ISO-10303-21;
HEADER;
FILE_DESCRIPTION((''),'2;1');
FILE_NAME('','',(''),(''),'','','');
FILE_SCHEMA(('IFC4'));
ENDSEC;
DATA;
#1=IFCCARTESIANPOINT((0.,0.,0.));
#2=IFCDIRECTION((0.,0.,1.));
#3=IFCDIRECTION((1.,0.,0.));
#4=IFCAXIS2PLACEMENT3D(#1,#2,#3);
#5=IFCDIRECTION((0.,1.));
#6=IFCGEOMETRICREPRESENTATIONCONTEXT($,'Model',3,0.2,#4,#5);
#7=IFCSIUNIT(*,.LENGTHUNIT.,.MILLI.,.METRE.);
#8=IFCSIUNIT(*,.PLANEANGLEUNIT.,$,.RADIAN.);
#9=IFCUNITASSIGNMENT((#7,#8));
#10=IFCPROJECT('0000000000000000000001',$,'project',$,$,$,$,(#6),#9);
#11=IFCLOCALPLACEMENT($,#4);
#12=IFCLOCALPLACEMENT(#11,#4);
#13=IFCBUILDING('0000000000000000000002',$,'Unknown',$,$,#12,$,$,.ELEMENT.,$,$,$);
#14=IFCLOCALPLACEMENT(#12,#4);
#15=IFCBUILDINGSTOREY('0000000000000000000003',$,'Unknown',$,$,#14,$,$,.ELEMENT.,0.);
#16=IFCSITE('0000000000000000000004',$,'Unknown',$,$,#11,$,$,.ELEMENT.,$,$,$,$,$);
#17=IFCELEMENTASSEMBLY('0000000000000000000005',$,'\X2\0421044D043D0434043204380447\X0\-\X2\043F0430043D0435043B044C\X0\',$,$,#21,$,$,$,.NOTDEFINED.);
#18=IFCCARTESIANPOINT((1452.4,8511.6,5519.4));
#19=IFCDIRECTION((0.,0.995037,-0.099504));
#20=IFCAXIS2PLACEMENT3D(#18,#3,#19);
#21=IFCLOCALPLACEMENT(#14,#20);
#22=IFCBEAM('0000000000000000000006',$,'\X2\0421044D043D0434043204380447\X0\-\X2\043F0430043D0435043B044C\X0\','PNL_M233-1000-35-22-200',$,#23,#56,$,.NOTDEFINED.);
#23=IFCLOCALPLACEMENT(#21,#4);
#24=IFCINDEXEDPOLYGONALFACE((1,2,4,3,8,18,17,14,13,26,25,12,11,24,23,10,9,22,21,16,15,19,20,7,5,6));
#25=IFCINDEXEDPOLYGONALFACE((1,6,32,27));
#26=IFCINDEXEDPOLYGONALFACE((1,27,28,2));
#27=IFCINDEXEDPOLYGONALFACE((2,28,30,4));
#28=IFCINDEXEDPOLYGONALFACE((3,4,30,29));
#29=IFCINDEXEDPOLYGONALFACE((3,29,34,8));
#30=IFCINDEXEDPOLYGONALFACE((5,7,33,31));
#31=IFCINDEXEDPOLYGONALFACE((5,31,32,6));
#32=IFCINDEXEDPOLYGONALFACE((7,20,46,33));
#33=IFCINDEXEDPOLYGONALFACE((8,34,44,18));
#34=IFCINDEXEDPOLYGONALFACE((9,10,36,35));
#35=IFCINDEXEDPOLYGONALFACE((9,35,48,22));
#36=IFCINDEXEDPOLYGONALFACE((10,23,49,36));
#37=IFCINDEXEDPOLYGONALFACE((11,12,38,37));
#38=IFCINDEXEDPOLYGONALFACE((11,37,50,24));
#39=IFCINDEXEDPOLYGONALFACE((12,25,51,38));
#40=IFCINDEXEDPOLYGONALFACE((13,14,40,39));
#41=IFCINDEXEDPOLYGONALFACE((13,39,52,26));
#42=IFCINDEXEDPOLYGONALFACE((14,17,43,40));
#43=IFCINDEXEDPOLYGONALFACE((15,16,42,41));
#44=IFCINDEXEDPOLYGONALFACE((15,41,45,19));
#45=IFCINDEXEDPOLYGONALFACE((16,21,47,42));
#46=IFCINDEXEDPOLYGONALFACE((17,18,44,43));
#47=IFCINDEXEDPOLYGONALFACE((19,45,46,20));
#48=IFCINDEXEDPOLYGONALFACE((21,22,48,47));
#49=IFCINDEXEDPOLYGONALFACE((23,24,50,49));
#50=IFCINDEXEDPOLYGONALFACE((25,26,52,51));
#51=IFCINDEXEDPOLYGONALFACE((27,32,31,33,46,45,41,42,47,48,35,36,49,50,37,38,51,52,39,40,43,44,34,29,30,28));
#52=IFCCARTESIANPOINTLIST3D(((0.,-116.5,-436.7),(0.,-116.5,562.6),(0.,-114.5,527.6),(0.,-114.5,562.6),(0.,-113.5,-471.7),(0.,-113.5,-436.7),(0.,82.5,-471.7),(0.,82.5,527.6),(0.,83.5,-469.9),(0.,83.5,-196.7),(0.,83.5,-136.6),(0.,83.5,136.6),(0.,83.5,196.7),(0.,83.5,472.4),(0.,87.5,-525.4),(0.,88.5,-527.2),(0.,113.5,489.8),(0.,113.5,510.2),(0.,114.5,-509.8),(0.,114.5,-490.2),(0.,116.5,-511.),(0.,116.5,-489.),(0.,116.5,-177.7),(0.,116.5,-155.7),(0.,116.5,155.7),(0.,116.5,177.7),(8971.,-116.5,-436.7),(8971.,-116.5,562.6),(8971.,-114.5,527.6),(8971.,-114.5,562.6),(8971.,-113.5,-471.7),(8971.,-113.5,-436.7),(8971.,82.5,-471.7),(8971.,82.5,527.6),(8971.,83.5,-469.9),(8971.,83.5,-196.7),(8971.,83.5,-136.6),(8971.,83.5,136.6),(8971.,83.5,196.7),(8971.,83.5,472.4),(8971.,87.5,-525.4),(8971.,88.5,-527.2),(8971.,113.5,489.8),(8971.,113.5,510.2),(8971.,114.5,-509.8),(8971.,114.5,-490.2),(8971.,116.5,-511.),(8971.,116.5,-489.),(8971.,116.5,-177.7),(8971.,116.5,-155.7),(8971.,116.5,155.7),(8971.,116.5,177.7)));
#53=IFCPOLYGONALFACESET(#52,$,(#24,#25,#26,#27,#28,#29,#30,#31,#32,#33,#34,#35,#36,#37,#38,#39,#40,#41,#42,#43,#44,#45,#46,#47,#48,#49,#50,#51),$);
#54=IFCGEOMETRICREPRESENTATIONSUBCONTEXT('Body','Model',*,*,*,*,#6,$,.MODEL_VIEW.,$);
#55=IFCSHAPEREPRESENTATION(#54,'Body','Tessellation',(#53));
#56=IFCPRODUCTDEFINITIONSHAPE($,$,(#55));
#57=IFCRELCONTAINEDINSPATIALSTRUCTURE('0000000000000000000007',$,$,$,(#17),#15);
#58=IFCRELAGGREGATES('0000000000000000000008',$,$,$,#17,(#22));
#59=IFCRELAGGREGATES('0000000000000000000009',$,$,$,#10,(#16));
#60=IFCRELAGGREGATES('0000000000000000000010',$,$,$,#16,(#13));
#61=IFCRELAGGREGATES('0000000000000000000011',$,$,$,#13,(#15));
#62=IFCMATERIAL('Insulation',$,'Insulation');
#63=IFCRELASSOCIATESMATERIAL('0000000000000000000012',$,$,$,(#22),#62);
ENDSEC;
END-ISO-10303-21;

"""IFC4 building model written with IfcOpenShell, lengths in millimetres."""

from ifc_helpers import new_model, si_unit, direction, frame, origin_with_axes, place, context, subcontext, project, spatial, line, indexed_curve, outline, extrude, material, element, aggregate, save


model = new_model("IFC4")

# Units and contexts
model_context = context("Model", 3, precision=0.2, world=origin_with_axes(), true_north=direction((0.0, 1.0)))
body_context = subcontext(model_context, "Body", "Model", "MODEL_VIEW")
ifc_project = project(units=[si_unit("LENGTHUNIT", "METRE", prefix="MILLI"), si_unit("PLANEANGLEUNIT", "RADIAN")], contexts=[model_context])

# Site, building, storey
site_placement = place(None, origin_with_axes())
site = spatial("IfcSite", under=ifc_project, at=site_placement, Name="Unknown", CompositionType="ELEMENT")
building_placement = place(site_placement, origin_with_axes())
building = spatial("IfcBuilding", under=site, at=building_placement, Name="Unknown", CompositionType="ELEMENT")
storey_placement = place(building_placement, origin_with_axes())
storey = spatial("IfcBuildingStorey", under=building, at=storey_placement, Name="Unknown", CompositionType="ELEMENT", Elevation=0.0)

# Element assembly, beam
ifc_material_1 = material(Name="Insulation", Category="Insulation")
assembly_1_placement = place(storey_placement, frame((1452.4, 8511.6, 5519.4), z_axis=(1.0, 0.0, 0.0), x_axis=(0.0, 0.995037, -0.099504)))
assembly_1 = element("IfcElementAssembly", 1, at=assembly_1_placement, inside=storey, Name="Сэндвич-панель", PredefinedType="NOTDEFINED")
beam_1_placement = place(assembly_1_placement, origin_with_axes())
beam_1 = element("IfcBeam", 2, at=beam_1_placement, material=ifc_material_1, Name="Сэндвич-панель", Description="PNL_M233-1000-35-22-200", PredefinedType="NOTDEFINED", context=body_context, shape_type="SolidModel", body=[
    extrude(outline(indexed_curve([(-509.8, 114.5), (-490.2, 114.5), (-471.7, 82.5), (-471.7, -113.5), (-436.7, -113.5), (-436.7, -116.5), (562.6, -116.5), (562.6, -114.5), (527.6, -114.5), (527.6, 82.5), (510.2, 113.5), (489.8, 113.5), (472.4, 83.5), (196.7, 83.5), (177.7, 116.5), (155.7, 116.5), (136.6, 83.5), (-136.6, 83.5), (-155.7, 116.5), (-177.7, 116.5), (-196.7, 83.5), (-469.9, 83.5), (-489.0, 116.5), (-511.0, 116.5), (-527.2, 88.5), (-525.4, 87.5)], segments=[line(1, 2, 3, 4, 5, 6, 7, 8, 9, 10, 11, 12, 13, 14, 15, 16, 17, 18, 19, 20, 21, 22, 23, 24, 25, 26, 1)])), frame((0.0, 0.0, 0.0), z_axis=(-1.0, 0.0, 0.0), x_axis=(0.0, 0.0, 1.0)), (0.0, 0.0, -1.0), 8971.0),
])
aggregate(assembly_1, [beam_1])

save(model, "model.ifc")
